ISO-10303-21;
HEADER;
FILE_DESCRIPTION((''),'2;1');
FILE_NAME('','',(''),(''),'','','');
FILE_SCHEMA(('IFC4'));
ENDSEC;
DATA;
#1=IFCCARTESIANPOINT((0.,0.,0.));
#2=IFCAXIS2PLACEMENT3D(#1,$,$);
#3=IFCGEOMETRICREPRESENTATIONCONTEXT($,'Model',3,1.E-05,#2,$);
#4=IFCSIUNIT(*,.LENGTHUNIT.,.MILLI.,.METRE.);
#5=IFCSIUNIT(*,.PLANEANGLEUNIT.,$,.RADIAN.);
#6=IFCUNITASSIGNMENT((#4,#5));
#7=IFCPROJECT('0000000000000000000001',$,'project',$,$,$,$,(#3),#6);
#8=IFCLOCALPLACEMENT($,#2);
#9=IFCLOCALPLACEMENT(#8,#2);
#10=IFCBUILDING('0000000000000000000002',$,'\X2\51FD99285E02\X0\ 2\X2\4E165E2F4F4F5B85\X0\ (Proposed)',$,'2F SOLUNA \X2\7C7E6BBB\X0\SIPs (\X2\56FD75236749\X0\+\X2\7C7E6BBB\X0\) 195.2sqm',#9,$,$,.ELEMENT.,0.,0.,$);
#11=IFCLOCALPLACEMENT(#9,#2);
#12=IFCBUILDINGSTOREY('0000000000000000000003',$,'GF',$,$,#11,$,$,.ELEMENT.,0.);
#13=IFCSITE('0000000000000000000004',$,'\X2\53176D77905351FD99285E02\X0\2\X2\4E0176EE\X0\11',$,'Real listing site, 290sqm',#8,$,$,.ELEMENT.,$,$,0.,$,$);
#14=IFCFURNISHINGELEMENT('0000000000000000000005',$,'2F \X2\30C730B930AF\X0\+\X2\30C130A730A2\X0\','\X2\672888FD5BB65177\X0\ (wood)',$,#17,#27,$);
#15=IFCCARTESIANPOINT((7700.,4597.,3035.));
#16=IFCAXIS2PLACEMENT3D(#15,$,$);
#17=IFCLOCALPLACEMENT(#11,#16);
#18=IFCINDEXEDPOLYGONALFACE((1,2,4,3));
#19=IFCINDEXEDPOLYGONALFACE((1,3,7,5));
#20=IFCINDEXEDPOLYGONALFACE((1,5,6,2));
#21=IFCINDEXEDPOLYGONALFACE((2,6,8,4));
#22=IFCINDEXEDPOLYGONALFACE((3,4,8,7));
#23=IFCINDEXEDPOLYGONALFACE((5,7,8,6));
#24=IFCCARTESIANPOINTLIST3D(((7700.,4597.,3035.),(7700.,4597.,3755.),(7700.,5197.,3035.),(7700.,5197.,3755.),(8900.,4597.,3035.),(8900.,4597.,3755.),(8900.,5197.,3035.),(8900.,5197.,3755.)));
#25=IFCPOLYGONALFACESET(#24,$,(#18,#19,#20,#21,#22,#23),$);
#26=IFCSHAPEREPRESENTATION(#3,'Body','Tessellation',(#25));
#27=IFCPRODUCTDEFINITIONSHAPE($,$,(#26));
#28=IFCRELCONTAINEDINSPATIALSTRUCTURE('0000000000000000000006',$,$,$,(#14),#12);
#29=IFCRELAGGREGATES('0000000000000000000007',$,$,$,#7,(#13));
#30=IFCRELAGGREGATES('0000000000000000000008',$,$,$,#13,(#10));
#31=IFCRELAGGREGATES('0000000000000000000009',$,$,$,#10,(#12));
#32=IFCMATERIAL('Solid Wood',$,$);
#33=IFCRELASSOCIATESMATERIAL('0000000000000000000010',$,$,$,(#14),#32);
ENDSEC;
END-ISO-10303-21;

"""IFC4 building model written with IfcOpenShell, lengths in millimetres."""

from ifc_helpers import new_model, si_unit, frame, frame_2d, origin, place, context, project, spatial, rectangle, extrude, material, element, save


model = new_model("IFC4")

# Units and contexts
model_context = context("Model", 3, precision=1e-05, world=origin())
ifc_project = project(units=[si_unit("LENGTHUNIT", "METRE", prefix="MILLI"), si_unit("PLANEANGLEUNIT", "RADIAN")], contexts=[model_context])

# Site, building, storey
site_placement = place(None, origin())
site = spatial("IfcSite", under=ifc_project, at=site_placement, Name="北海道函館市2丁目11", ObjectType="Real listing site, 290sqm", CompositionType="ELEMENT", RefElevation=0.0)
building_placement = place(site_placement, origin())
building = spatial("IfcBuilding", under=site, at=building_placement, Name="函館市 2世帯住宅 (Proposed)", ObjectType="2F SOLUNA 籾殻SIPs (国産杉+籾殻) 195.2sqm", CompositionType="ELEMENT", ElevationOfRefHeight=0.0, ElevationOfTerrain=0.0)
storey_placement = place(building_placement, origin())
storey = spatial("IfcBuildingStorey", under=building, at=storey_placement, Name="GF", CompositionType="ELEMENT", Elevation=0.0)

# Shared definitions
ifc_material_1 = material(Name="Solid Wood")

# Furnishing element
furnishing_1_placement = place(storey_placement, frame((7700.0, 4597.0, 3035.0)))
element("IfcFurnishingElement", 1, at=furnishing_1_placement, inside=storey, material=ifc_material_1, Name="2F デスク+チェア", Description="木製家具 (wood)", context=model_context, shape_type="SweptSolid", body=[
    extrude(rectangle(XDim=1200.0, YDim=600.0, at=frame_2d((600.0, 300.0))), frame((7700.0, 4597.0, 3035.0)), (0.0, 0.0, 1.0), 720.0),
])

save(model, "model.ifc")
